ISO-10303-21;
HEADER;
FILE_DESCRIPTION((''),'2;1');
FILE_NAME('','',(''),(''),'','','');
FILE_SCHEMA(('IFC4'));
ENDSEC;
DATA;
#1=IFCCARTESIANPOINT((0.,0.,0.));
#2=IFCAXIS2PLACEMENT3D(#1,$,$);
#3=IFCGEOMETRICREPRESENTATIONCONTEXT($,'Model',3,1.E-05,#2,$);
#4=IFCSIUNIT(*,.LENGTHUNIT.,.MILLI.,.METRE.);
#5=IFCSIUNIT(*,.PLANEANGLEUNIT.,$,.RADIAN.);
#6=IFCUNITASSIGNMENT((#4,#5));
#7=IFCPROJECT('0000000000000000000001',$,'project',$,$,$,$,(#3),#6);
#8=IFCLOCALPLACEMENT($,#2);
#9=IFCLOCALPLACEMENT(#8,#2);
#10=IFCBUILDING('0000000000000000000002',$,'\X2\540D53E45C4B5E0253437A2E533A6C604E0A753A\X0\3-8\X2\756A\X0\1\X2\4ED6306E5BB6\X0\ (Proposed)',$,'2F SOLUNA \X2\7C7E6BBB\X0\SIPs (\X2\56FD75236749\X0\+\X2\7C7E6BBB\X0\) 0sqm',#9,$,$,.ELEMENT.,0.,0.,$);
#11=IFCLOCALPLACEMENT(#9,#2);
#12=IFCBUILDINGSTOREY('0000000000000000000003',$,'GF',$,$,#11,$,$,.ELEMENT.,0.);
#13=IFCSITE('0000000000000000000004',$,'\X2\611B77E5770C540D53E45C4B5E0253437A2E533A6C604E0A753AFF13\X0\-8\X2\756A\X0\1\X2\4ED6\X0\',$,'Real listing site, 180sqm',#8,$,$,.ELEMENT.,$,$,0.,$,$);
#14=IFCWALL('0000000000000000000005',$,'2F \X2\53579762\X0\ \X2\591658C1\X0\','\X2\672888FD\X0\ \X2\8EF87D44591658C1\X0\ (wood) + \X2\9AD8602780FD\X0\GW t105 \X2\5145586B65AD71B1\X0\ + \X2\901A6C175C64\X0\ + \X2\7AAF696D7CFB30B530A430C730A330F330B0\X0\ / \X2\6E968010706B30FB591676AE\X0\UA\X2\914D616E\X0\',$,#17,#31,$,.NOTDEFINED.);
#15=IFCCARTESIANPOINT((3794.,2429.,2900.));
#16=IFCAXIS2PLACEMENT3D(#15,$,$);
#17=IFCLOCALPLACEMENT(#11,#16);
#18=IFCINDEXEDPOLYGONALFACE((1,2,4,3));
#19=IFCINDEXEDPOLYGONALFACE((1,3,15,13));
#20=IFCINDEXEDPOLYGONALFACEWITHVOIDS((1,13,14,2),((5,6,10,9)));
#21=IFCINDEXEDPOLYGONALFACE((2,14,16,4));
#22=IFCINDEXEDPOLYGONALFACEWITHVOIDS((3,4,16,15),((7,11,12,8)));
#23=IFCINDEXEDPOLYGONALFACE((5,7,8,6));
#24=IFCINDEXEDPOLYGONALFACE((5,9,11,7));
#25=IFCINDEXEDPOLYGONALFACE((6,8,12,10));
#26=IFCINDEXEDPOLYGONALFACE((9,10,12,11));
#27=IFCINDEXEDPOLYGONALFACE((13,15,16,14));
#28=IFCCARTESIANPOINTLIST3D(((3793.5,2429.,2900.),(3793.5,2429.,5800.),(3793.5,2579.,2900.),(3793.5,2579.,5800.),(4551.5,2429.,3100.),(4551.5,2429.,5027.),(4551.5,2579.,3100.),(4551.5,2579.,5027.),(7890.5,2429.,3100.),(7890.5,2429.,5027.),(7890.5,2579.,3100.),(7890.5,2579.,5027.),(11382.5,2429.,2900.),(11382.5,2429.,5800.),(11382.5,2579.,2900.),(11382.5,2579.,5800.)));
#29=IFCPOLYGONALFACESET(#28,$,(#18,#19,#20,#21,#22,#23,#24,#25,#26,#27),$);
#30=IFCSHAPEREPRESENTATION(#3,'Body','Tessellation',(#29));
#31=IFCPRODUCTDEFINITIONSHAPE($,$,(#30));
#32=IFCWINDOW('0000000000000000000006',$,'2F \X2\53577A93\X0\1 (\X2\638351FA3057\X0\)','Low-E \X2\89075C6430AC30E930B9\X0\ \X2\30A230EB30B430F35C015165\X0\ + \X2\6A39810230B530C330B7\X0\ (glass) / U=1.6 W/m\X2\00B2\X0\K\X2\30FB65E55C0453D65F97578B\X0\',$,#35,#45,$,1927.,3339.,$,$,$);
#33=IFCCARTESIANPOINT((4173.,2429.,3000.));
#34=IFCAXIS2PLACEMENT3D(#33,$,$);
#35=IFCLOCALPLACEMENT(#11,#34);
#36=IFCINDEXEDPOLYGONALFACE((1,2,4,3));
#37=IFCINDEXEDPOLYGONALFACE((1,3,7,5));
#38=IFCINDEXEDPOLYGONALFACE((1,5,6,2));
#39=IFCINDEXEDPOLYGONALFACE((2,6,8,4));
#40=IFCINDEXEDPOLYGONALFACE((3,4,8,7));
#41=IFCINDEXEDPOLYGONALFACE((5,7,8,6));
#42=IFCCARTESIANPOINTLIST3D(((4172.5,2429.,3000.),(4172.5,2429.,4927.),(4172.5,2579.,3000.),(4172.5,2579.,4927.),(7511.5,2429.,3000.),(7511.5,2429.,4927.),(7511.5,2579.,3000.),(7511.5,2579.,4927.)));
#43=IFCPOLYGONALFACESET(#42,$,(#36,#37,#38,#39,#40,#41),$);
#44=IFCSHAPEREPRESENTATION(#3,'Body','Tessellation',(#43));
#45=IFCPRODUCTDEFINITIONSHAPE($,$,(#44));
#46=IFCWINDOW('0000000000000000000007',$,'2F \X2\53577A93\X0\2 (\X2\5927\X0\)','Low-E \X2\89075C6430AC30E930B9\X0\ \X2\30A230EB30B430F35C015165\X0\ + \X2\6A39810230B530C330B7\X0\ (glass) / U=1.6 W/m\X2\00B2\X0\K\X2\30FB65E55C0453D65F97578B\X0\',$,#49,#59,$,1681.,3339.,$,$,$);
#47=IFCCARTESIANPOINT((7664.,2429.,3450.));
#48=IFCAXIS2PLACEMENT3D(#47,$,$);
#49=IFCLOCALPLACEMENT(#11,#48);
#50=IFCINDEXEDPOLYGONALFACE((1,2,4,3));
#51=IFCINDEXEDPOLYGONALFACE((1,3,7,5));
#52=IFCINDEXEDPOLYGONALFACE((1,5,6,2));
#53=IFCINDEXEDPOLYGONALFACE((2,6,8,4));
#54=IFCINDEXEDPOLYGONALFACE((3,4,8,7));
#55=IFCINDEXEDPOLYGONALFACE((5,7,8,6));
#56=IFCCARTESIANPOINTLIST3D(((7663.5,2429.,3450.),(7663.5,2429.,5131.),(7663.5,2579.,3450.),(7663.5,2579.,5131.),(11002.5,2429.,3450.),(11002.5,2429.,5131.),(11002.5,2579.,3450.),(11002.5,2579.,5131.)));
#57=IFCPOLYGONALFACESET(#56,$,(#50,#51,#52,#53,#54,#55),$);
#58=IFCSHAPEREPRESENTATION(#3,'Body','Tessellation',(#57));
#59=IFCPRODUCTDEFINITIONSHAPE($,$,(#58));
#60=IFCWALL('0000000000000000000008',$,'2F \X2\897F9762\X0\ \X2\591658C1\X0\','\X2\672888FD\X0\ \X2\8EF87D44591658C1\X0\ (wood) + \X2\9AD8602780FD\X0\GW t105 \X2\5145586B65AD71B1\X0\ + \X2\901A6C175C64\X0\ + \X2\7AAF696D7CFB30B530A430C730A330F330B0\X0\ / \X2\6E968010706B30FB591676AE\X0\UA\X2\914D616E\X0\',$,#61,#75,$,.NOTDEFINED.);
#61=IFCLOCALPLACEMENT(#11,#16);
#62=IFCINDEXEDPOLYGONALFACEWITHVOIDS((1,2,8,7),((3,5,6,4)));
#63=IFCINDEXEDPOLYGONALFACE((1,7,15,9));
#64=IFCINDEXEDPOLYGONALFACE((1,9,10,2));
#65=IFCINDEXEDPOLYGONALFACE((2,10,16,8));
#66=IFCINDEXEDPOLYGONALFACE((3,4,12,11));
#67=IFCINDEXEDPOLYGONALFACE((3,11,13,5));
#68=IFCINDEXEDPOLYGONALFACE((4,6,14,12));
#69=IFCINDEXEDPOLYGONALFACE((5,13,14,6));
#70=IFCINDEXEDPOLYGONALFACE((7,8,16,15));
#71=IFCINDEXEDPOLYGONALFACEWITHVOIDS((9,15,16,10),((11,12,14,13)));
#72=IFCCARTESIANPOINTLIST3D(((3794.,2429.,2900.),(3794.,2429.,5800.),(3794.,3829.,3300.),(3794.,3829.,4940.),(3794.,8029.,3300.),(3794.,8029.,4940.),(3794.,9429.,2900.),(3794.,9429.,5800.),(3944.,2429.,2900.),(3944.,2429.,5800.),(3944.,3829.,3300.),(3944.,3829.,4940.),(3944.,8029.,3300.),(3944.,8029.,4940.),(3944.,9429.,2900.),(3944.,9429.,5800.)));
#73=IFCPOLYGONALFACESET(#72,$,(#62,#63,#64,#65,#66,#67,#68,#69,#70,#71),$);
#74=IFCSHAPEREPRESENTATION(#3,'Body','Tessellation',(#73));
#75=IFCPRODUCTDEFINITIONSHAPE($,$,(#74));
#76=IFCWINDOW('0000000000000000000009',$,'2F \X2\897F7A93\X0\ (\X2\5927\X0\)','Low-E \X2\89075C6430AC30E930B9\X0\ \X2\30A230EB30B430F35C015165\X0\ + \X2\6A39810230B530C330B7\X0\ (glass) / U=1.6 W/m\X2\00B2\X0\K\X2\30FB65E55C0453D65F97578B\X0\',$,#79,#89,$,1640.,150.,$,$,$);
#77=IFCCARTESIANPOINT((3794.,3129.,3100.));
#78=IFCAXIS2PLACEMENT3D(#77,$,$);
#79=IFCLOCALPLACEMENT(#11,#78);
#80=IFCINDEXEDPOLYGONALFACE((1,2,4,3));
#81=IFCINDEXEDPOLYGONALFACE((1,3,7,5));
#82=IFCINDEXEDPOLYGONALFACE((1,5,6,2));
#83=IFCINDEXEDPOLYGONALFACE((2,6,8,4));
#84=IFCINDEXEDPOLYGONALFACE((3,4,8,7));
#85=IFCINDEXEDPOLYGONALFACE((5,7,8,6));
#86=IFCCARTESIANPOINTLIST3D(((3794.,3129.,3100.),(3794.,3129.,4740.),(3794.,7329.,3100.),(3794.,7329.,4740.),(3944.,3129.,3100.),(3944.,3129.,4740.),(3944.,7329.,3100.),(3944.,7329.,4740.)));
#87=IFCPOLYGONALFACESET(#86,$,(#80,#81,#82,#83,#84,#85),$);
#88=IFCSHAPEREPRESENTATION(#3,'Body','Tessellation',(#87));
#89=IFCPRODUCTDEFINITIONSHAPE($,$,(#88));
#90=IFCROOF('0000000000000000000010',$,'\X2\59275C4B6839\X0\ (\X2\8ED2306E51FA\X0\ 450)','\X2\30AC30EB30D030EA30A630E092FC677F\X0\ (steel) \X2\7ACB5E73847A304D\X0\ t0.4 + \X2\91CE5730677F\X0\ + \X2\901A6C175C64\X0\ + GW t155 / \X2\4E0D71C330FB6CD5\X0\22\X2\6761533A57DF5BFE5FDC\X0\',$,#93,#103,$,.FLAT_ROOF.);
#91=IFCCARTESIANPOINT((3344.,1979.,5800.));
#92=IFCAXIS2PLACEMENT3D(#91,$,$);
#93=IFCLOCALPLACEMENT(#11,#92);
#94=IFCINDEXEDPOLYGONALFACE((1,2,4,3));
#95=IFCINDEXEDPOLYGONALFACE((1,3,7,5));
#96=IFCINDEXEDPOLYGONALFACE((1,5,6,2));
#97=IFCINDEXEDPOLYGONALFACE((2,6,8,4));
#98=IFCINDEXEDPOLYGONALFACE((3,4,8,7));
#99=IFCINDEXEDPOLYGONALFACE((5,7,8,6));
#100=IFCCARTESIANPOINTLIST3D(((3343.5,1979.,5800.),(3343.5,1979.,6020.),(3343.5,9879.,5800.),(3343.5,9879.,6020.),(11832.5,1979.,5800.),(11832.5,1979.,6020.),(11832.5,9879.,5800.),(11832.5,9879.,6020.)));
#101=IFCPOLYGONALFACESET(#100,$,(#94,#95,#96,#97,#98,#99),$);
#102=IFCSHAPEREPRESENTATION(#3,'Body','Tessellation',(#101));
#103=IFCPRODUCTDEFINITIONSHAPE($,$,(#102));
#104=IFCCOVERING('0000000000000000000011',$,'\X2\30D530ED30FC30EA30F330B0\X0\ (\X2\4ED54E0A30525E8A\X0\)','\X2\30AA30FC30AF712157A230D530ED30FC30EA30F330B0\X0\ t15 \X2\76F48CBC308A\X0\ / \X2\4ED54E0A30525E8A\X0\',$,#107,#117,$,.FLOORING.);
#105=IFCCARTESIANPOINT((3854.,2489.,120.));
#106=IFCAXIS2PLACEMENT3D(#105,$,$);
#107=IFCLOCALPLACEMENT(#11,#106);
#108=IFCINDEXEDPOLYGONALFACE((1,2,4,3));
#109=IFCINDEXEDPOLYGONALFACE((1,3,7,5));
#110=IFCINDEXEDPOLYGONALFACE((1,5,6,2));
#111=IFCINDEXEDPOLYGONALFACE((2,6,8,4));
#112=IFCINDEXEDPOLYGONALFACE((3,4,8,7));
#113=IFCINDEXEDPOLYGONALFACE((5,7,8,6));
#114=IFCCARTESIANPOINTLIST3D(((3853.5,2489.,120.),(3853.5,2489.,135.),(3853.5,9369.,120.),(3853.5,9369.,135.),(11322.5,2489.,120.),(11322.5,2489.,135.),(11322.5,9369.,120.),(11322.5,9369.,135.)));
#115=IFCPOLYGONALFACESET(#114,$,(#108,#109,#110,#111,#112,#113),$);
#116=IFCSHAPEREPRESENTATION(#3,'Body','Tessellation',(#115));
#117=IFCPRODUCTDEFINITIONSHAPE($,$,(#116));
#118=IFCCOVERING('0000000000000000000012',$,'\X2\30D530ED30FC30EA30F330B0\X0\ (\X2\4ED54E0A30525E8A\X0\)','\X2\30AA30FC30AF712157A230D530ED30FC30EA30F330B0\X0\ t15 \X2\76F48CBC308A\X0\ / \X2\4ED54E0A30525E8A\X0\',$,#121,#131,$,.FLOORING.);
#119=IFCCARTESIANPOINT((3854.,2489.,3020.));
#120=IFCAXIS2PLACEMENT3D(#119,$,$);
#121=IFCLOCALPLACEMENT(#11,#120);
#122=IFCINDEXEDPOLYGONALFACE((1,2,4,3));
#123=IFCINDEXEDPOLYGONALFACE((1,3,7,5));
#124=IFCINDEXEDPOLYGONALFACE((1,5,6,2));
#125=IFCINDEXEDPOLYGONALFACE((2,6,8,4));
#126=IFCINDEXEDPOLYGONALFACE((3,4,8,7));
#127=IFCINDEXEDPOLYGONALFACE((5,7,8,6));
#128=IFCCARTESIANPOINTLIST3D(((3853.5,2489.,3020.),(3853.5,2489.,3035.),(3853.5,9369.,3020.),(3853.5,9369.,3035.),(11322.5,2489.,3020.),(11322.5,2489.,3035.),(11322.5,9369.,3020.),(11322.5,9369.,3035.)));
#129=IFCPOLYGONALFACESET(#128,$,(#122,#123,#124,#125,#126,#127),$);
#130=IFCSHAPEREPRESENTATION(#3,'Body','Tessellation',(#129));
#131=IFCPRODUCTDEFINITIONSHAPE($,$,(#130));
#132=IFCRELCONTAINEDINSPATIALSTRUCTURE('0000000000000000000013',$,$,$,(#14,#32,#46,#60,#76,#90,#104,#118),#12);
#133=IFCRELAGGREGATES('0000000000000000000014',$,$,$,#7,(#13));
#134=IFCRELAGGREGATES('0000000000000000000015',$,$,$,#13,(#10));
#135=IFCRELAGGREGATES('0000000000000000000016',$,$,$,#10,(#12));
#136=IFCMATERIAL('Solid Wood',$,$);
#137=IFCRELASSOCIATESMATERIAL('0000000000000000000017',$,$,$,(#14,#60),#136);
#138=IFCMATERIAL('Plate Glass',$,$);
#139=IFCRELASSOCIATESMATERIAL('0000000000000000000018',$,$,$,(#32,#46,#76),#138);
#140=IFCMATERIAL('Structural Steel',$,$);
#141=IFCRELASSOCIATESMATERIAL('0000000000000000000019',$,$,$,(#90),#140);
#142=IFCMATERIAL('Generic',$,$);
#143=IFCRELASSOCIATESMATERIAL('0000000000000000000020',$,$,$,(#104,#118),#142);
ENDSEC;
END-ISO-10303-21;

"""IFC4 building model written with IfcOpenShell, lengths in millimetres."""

from ifc_helpers import new_model, si_unit, frame, frame_2d, origin, place, context, project, spatial, rectangle, extrude, material, element, fill, save


model = new_model("IFC4")

# Units and contexts
model_context = context("Model", 3, precision=1e-05, world=origin())
ifc_project = project(units=[si_unit("LENGTHUNIT", "METRE", prefix="MILLI"), si_unit("PLANEANGLEUNIT", "RADIAN")], contexts=[model_context])

# Site, building, storey
site_placement = place(None, origin())
site = spatial("IfcSite", under=ifc_project, at=site_placement, Name="愛知県名古屋市千種区池上町３-8番1他", ObjectType="Real listing site, 180sqm", CompositionType="ELEMENT", RefElevation=0.0)
building_placement = place(site_placement, origin())
building = spatial("IfcBuilding", under=site, at=building_placement, Name="名古屋市千種区池上町3-8番1他の家 (Proposed)", ObjectType="2F SOLUNA 籾殻SIPs (国産杉+籾殻) 0sqm", CompositionType="ELEMENT", ElevationOfRefHeight=0.0, ElevationOfTerrain=0.0)
storey_placement = place(building_placement, origin())
storey = spatial("IfcBuildingStorey", under=building, at=storey_placement, Name="GF", CompositionType="ELEMENT", Elevation=0.0)

# Shared definitions
ifc_material_1 = material(Name="Solid Wood")

# Shared definitions
ifc_material_2 = material(Name="Plate Glass")

# Wall, openings, windows
wall_1_placement = place(storey_placement, frame((3794.0, 2429.0, 2900.0)))
wall_1 = element("IfcWall", 1, at=wall_1_placement, inside=storey, material=ifc_material_1, Name="2F 南面 外壁", Description="木製 軸組外壁 (wood) + 高性能GW t105 充填断熱 + 通気層 + 窯業系サイディング / 準耐火・外皮UA配慮", PredefinedType="NOTDEFINED", context=model_context, shape_type="SweptSolid", body=[
    extrude(rectangle(XDim=7589.0, YDim=150.0, at=frame_2d((3794.0, 75.0))), frame((3794.0, 2429.0, 2900.0)), (0.0, 0.0, 1.0), 2900.0),
])
opening_1_placement = place(storey_placement, frame((4173.0, 2429.0, 3000.0)))
opening_1 = element("IfcOpeningElement", 2, at=opening_1_placement, cuts=wall_1, PredefinedType="NOTDEFINED", context=model_context, shape_type="SweptSolid", body=[
    extrude(rectangle(XDim=3339.0, YDim=150.0, at=frame_2d((1669.0, 75.0))), frame((4173.0, 2429.0, 3000.0)), (0.0, 0.0, 1.0), 1927.0),
])
opening_2_placement = place(storey_placement, frame((7664.0, 2429.0, 3450.0)))
opening_2 = element("IfcOpeningElement", 3, at=opening_2_placement, cuts=wall_1, PredefinedType="NOTDEFINED", context=model_context, shape_type="SweptSolid", body=[
    extrude(rectangle(XDim=3339.0, YDim=150.0, at=frame_2d((1669.0, 75.0))), frame((7664.0, 2429.0, 3450.0)), (0.0, 0.0, 1.0), 1681.0),
])
window_1_placement = place(storey_placement, frame((4173.0, 2429.0, 3000.0)))
window_1 = element("IfcWindow", 4, at=window_1_placement, inside=storey, material=ifc_material_2, Name="2F 南窓1 (掃出し)", Description="Low-E 複層ガラス アルゴン封入 + 樹脂サッシ (glass) / U=1.6 W/m²K・日射取得型", OverallHeight=1927.0, OverallWidth=3339.0, context=model_context, shape_type="SweptSolid", body=[
    extrude(rectangle(XDim=3339.0, YDim=150.0, at=frame_2d((1669.0, 75.0))), frame((4173.0, 2429.0, 3000.0)), (0.0, 0.0, 1.0), 1927.0),
])
fill(opening_1, window_1)
window_2_placement = place(storey_placement, frame((7664.0, 2429.0, 3450.0)))
window_2 = element("IfcWindow", 5, at=window_2_placement, inside=storey, material=ifc_material_2, Name="2F 南窓2 (大)", Description="Low-E 複層ガラス アルゴン封入 + 樹脂サッシ (glass) / U=1.6 W/m²K・日射取得型", OverallHeight=1681.0, OverallWidth=3339.0, context=model_context, shape_type="SweptSolid", body=[
    extrude(rectangle(XDim=3339.0, YDim=150.0, at=frame_2d((1669.0, 75.0))), frame((7664.0, 2429.0, 3450.0)), (0.0, 0.0, 1.0), 1681.0),
])
fill(opening_2, window_2)

# Wall, opening, window
wall_2_placement = place(storey_placement, frame((3794.0, 2429.0, 2900.0)))
wall_2 = element("IfcWall", 6, at=wall_2_placement, inside=storey, material=ifc_material_1, Name="2F 西面 外壁", Description="木製 軸組外壁 (wood) + 高性能GW t105 充填断熱 + 通気層 + 窯業系サイディング / 準耐火・外皮UA配慮", PredefinedType="NOTDEFINED", context=model_context, shape_type="SweptSolid", body=[
    extrude(rectangle(XDim=150.0, YDim=7000.0, at=frame_2d((75.0, 3500.0))), frame((3794.0, 2429.0, 2900.0)), (0.0, 0.0, 1.0), 2900.0),
])
opening_3_placement = place(storey_placement, frame((3794.0, 3129.0, 3100.0)))
opening_3 = element("IfcOpeningElement", 7, at=opening_3_placement, cuts=wall_2, PredefinedType="NOTDEFINED", context=model_context, shape_type="SweptSolid", body=[
    extrude(rectangle(XDim=150.0, YDim=4200.0, at=frame_2d((75.0, 2100.0))), frame((3794.0, 3129.0, 3100.0)), (0.0, 0.0, 1.0), 1640.0),
])
window_3_placement = place(storey_placement, frame((3794.0, 3129.0, 3100.0)))
window_3 = element("IfcWindow", 8, at=window_3_placement, inside=storey, material=ifc_material_2, Name="2F 西窓 (大)", Description="Low-E 複層ガラス アルゴン封入 + 樹脂サッシ (glass) / U=1.6 W/m²K・日射取得型", OverallHeight=1640.0, OverallWidth=150.0, context=model_context, shape_type="SweptSolid", body=[
    extrude(rectangle(XDim=150.0, YDim=4200.0, at=frame_2d((75.0, 2100.0))), frame((3794.0, 3129.0, 3100.0)), (0.0, 0.0, 1.0), 1640.0),
])
fill(opening_3, window_3)

# Roof
ifc_material_3 = material(Name="Structural Steel")
roof_placement = place(storey_placement, frame((3344.0, 1979.0, 5800.0)))
element("IfcRoof", 9, at=roof_placement, inside=storey, material=ifc_material_3, Name="大屋根 (軒の出 450)", Description="ガルバリウム鋼板 (steel) 立平葺き t0.4 + 野地板 + 通気層 + GW t155 / 不燃・法22条区域対応", PredefinedType="FLAT_ROOF", context=model_context, shape_type="SweptSolid", body=[
    extrude(rectangle(XDim=8489.0, YDim=7900.0, at=frame_2d((4244.0, 3950.0))), frame((3344.0, 1979.0, 5800.0)), (0.0, 0.0, 1.0), 220.0),
])

# Coverings
ifc_material_4 = material(Name="Generic")
covering_1_placement = place(storey_placement, frame((3854.0, 2489.0, 120.0)))
element("IfcCovering", 10, at=covering_1_placement, inside=storey, material=ifc_material_4, Name="フローリング (仕上げ床)", Description="オーク無垢フローリング t15 直貼り / 仕上げ床", PredefinedType="FLOORING", context=model_context, shape_type="SweptSolid", body=[
    extrude(rectangle(XDim=7469.0, YDim=6880.0, at=frame_2d((3734.0, 3440.0))), frame((3854.0, 2489.0, 120.0)), (0.0, 0.0, 1.0), 15.0),
])
covering_2_placement = place(storey_placement, frame((3854.0, 2489.0, 3020.0)))
element("IfcCovering", 11, at=covering_2_placement, inside=storey, material=ifc_material_4, Name="フローリング (仕上げ床)", Description="オーク無垢フローリング t15 直貼り / 仕上げ床", PredefinedType="FLOORING", context=model_context, shape_type="SweptSolid", body=[
    extrude(rectangle(XDim=7469.0, YDim=6880.0, at=frame_2d((3734.0, 3440.0))), frame((3854.0, 2489.0, 3020.0)), (0.0, 0.0, 1.0), 15.0),
])

save(model, "model.ifc")
